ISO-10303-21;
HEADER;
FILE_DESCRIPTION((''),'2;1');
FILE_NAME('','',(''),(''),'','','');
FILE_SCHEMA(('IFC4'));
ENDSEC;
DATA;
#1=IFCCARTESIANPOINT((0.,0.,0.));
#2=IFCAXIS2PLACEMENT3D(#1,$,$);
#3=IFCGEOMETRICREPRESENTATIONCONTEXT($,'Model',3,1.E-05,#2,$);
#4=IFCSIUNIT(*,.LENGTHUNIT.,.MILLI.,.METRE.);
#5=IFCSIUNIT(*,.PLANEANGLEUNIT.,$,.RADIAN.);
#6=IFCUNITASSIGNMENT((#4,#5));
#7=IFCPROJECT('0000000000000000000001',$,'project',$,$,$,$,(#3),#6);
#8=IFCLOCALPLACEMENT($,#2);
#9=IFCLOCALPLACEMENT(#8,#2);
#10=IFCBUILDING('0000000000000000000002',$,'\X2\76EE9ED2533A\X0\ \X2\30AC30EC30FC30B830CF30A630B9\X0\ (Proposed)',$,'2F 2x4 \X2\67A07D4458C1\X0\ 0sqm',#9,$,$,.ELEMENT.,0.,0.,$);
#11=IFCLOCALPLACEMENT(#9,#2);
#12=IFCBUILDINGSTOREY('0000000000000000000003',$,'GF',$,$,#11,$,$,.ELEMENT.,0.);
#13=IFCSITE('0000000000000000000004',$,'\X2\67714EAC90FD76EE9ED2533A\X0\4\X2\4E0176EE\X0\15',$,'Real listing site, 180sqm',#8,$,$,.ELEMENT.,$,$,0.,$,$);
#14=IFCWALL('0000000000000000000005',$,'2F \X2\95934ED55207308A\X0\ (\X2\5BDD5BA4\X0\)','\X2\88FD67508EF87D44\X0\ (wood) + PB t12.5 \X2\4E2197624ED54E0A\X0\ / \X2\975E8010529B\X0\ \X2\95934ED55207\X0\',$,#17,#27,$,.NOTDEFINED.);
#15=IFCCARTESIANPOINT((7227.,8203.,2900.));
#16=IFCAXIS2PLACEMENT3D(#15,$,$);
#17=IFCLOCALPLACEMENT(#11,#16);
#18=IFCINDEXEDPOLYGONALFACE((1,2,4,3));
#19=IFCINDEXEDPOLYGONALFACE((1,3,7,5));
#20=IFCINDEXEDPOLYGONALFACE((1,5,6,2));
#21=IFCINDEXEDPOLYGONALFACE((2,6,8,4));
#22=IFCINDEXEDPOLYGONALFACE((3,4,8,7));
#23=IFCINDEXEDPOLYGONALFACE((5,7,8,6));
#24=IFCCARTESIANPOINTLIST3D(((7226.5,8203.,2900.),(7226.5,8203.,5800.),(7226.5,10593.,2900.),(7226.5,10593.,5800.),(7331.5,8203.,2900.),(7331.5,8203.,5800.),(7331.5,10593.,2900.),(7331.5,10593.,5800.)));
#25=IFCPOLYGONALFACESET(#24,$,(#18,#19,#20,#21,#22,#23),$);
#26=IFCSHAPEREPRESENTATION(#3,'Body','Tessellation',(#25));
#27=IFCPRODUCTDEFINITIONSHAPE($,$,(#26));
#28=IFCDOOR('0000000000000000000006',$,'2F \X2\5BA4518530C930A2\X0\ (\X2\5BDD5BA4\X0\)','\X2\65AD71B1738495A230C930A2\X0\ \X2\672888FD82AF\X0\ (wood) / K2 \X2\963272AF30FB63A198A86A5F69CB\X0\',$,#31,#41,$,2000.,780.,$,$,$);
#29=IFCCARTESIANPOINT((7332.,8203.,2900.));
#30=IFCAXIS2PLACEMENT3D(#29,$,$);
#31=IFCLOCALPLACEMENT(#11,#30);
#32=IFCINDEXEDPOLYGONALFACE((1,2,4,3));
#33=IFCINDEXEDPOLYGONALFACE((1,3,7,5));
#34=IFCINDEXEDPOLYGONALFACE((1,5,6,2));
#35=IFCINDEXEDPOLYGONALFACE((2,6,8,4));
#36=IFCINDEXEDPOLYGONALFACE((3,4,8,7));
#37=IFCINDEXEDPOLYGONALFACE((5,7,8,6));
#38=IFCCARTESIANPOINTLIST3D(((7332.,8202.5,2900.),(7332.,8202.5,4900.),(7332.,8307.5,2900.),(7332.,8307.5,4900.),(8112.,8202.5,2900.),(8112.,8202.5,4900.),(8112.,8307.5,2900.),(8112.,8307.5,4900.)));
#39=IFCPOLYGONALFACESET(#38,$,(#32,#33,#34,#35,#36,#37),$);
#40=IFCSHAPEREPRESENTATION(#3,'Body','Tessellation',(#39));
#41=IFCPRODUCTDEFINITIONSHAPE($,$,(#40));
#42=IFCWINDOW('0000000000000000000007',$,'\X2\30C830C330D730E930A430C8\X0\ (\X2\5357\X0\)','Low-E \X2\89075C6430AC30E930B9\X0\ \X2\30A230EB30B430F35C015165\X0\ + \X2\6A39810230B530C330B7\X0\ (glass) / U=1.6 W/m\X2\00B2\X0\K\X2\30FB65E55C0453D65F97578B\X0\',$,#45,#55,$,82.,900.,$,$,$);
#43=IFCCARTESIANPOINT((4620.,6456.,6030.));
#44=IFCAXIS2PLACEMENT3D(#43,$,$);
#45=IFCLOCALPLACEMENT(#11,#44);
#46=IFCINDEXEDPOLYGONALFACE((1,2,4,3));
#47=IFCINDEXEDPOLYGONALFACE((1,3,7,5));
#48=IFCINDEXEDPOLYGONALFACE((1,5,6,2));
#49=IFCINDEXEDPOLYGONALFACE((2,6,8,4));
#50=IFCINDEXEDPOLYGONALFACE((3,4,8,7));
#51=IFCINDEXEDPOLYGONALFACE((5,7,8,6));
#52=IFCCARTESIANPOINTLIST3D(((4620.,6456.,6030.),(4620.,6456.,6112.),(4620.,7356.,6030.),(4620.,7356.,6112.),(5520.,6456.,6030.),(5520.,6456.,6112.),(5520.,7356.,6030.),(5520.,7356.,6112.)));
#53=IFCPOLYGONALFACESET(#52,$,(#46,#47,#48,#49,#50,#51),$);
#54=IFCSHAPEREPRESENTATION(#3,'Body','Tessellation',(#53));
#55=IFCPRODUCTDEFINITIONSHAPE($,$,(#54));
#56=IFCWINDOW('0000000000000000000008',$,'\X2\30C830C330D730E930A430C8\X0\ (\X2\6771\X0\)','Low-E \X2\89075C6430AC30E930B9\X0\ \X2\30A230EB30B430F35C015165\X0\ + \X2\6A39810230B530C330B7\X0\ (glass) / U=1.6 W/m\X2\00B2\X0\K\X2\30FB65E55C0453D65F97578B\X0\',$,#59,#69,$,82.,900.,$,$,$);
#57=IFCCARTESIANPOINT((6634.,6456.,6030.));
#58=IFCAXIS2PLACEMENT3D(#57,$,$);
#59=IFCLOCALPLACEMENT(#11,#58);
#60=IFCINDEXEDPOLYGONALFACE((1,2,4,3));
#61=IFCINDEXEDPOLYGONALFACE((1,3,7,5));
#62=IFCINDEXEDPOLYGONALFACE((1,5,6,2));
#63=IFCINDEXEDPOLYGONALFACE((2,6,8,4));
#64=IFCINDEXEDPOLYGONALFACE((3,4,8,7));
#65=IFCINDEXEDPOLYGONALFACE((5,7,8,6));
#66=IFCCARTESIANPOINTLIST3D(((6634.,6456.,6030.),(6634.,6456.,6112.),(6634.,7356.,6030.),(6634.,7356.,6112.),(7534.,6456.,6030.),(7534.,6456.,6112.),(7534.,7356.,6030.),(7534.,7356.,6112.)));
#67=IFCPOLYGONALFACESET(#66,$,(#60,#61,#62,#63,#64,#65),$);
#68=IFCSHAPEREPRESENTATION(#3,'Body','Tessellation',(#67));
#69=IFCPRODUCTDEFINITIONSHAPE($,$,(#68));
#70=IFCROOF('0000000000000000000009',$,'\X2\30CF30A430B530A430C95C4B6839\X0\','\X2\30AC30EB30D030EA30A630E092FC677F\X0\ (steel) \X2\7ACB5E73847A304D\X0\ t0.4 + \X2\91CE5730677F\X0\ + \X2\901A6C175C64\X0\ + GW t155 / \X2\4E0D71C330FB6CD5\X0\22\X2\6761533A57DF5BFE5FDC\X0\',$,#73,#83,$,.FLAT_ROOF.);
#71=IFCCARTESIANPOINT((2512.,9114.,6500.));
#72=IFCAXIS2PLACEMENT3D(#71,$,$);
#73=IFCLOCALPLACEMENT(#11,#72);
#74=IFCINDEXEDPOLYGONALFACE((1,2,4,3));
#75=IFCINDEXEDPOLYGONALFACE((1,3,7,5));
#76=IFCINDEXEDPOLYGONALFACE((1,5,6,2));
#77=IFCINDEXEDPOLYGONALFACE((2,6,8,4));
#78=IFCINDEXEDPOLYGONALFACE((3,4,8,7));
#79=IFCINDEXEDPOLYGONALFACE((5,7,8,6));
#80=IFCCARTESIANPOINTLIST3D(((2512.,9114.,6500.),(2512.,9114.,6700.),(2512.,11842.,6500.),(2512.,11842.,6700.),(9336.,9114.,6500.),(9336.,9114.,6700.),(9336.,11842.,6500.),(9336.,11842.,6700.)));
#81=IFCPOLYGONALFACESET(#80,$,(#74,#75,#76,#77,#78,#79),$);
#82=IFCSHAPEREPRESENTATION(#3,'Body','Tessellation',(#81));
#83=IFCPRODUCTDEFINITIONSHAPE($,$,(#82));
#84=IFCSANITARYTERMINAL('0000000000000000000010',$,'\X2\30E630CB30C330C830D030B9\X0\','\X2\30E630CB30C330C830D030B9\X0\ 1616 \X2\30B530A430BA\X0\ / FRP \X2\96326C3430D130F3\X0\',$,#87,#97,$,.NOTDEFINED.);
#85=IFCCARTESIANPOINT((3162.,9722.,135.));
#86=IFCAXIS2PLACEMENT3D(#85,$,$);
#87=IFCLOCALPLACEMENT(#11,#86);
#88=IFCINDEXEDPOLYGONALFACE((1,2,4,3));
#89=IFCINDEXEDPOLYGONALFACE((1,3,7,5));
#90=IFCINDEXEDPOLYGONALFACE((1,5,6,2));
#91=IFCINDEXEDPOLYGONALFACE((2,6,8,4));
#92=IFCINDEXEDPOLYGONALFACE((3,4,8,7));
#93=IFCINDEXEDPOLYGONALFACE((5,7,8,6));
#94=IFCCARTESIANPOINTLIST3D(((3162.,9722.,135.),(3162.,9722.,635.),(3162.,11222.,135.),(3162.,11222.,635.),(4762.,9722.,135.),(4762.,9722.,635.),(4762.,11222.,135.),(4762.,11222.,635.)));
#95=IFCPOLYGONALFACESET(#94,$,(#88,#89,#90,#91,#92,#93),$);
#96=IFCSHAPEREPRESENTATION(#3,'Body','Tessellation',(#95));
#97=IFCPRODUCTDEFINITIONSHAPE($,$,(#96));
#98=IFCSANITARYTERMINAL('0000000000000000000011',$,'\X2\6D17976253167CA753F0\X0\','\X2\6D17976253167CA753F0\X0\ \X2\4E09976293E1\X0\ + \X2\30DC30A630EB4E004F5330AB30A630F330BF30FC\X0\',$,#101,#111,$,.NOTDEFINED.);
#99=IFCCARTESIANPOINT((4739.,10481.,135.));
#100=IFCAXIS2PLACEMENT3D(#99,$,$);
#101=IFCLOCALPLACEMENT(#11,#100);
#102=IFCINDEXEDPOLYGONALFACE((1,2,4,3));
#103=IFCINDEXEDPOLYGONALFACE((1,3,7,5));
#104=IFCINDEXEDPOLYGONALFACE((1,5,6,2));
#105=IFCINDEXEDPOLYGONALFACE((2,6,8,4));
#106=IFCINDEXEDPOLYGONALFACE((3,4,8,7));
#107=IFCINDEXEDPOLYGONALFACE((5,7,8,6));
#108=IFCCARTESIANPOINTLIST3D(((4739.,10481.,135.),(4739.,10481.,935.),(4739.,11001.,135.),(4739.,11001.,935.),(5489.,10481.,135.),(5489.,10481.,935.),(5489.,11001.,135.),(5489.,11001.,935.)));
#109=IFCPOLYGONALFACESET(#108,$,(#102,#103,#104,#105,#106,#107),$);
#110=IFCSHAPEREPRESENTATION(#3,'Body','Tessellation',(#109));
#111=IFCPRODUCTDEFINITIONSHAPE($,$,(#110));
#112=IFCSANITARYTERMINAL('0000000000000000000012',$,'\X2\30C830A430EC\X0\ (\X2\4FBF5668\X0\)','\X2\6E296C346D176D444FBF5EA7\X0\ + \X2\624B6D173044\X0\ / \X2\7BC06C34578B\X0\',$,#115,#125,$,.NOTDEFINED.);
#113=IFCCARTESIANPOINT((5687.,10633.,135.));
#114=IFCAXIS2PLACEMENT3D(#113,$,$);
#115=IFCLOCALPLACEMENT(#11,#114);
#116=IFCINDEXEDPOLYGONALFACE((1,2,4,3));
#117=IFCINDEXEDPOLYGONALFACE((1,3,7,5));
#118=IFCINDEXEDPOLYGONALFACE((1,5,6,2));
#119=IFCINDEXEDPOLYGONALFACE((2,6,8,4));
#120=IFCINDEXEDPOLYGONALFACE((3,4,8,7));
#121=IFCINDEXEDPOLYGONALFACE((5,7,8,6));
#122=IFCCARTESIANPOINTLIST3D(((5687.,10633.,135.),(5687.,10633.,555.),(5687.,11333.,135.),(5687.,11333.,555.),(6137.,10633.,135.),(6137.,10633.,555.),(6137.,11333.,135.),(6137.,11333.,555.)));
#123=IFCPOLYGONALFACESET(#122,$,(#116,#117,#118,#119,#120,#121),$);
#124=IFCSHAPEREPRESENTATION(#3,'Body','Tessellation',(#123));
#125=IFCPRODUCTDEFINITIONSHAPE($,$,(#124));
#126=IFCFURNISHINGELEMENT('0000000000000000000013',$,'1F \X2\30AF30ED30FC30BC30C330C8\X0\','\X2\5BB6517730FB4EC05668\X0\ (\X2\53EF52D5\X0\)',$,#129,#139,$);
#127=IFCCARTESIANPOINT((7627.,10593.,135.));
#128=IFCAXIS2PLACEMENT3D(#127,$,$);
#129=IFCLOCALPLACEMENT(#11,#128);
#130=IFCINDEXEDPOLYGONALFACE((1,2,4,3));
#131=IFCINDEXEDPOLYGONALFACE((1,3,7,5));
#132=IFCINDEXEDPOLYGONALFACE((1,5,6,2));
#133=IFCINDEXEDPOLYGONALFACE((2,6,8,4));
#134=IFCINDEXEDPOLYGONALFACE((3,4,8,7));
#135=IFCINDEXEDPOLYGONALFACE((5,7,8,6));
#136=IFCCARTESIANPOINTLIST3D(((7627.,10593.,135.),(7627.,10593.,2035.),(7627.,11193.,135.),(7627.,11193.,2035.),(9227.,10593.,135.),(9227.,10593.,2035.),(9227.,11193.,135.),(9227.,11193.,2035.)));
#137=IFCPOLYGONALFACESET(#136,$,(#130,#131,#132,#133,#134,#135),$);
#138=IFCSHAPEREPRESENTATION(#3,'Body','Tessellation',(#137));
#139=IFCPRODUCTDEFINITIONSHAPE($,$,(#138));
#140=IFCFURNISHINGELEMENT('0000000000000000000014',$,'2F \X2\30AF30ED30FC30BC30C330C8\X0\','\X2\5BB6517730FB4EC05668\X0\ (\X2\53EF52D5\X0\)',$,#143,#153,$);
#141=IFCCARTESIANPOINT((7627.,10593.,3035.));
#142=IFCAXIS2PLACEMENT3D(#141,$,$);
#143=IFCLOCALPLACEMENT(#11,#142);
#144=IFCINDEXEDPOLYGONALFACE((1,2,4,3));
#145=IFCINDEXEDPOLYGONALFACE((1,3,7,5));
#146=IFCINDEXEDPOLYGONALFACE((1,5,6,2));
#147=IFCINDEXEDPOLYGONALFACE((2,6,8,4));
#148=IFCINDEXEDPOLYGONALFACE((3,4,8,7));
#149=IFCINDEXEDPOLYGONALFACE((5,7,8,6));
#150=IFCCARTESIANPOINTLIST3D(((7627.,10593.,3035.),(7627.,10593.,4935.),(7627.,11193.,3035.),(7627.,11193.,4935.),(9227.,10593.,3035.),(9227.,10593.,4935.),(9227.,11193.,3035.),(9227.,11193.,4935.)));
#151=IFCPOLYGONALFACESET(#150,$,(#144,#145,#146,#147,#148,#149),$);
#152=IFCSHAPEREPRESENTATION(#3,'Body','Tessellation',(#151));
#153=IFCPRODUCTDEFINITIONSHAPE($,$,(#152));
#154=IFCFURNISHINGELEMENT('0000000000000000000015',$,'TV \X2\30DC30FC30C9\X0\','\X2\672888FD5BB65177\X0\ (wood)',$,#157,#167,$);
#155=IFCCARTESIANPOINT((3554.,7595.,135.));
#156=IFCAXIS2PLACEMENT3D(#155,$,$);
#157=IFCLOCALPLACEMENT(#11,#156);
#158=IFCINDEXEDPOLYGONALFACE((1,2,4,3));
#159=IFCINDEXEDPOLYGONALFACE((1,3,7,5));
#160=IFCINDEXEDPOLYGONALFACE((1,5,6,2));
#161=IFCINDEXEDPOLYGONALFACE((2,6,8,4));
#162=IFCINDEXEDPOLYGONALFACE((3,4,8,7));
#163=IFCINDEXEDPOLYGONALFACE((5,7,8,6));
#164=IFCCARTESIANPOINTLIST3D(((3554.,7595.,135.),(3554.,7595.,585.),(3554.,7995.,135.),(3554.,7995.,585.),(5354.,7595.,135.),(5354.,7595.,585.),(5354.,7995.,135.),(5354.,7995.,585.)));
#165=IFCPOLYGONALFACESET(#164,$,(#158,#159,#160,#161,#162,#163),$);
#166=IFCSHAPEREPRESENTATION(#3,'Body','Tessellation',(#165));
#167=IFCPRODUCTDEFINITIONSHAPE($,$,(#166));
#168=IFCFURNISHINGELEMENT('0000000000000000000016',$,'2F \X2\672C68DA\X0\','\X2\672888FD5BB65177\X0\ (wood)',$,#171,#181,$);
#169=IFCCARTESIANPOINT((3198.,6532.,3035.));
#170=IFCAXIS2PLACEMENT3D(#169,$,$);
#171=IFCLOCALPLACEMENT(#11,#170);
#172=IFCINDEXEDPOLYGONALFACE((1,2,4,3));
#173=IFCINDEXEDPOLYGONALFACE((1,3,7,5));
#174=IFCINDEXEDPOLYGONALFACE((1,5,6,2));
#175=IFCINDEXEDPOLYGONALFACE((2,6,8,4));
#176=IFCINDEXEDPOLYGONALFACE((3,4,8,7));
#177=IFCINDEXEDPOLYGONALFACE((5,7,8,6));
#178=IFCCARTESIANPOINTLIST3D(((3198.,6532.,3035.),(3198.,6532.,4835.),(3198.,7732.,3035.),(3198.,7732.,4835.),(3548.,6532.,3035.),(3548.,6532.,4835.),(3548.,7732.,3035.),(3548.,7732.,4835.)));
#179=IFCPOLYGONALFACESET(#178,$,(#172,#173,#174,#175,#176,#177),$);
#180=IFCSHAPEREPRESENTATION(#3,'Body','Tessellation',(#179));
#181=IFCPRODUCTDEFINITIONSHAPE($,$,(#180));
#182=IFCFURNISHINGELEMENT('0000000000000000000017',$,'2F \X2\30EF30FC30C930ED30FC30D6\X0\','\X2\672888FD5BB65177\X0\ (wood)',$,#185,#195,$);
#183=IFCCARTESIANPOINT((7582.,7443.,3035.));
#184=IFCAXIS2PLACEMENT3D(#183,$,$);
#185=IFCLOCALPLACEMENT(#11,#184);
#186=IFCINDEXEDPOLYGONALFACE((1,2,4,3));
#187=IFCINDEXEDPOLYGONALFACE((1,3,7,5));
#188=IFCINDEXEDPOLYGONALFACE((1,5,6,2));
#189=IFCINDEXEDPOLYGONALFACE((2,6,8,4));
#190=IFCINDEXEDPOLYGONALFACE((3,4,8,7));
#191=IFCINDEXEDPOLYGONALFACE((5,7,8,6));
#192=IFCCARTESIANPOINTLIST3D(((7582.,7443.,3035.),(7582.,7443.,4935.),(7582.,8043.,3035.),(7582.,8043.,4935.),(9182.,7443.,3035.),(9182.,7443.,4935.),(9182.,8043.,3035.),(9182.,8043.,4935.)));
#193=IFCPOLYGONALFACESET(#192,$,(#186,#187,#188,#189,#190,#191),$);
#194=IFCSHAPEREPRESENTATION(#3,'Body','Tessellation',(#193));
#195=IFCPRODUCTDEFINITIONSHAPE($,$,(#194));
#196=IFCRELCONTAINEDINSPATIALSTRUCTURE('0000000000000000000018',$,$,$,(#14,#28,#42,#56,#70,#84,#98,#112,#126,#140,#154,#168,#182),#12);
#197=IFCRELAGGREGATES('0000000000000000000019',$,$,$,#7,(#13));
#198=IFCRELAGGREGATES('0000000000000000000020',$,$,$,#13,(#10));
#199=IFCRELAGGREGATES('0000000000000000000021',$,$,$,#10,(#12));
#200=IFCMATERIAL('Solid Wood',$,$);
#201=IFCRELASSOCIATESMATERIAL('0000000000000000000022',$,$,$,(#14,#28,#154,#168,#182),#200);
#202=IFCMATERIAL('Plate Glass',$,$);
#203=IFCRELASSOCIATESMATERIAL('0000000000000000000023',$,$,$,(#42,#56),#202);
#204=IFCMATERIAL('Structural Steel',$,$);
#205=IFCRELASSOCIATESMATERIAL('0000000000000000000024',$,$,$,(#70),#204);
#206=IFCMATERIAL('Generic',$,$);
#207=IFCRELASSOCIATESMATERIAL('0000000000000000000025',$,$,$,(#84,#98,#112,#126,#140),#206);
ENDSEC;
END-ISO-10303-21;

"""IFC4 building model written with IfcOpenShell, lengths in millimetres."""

from ifc_helpers import new_model, si_unit, frame, frame_2d, origin, place, context, project, spatial, rectangle, extrude, material, element, save


model = new_model("IFC4")

# Units and contexts
model_context = context("Model", 3, precision=1e-05, world=origin())
ifc_project = project(units=[si_unit("LENGTHUNIT", "METRE", prefix="MILLI"), si_unit("PLANEANGLEUNIT", "RADIAN")], contexts=[model_context])

# Site, building, storey
site_placement = place(None, origin())
site = spatial("IfcSite", under=ifc_project, at=site_placement, Name="東京都目黒区4丁目15", ObjectType="Real listing site, 180sqm", CompositionType="ELEMENT", RefElevation=0.0)
building_placement = place(site_placement, origin())
building = spatial("IfcBuilding", under=site, at=building_placement, Name="目黒区 ガレージハウス (Proposed)", ObjectType="2F 2x4 枠組壁 0sqm", CompositionType="ELEMENT", ElevationOfRefHeight=0.0, ElevationOfTerrain=0.0)
storey_placement = place(building_placement, origin())
storey = spatial("IfcBuildingStorey", under=building, at=storey_placement, Name="GF", CompositionType="ELEMENT", Elevation=0.0)

# Shared definitions
ifc_material_1 = material(Name="Solid Wood")
ifc_material_2 = material(Name="Plate Glass")

# Wall
wall_1_placement = place(storey_placement, frame((7227.0, 8203.0, 2900.0)))
element("IfcWall", 1, at=wall_1_placement, inside=storey, material=ifc_material_1, Name="2F 間仕切り (寝室)", Description="製材軸組 (wood) + PB t12.5 両面仕上 / 非耐力 間仕切", PredefinedType="NOTDEFINED", context=model_context, shape_type="SweptSolid", body=[
    extrude(rectangle(XDim=105.0, YDim=2390.0, at=frame_2d((52.0, 1195.0))), frame((7227.0, 8203.0, 2900.0)), (0.0, 0.0, 1.0), 2900.0),
])

# Door
door_1_placement = place(storey_placement, frame((7332.0, 8203.0, 2900.0)))
element("IfcDoor", 2, at=door_1_placement, inside=storey, material=ifc_material_1, Name="2F 室内ドア (寝室)", Description="断熱玄関ドア 木製芯 (wood) / K2 防犯・採風機構", OverallHeight=2000.0, OverallWidth=780.0, context=model_context, shape_type="SweptSolid", body=[
    extrude(rectangle(XDim=780.0, YDim=105.0, at=frame_2d((390.0, 52.0))), frame((7332.0, 8203.0, 2900.0)), (0.0, 0.0, 1.0), 2000.0),
])

# Windows
window_1_placement = place(storey_placement, frame((4620.0, 6456.0, 6030.0)))
element("IfcWindow", 3, at=window_1_placement, inside=storey, material=ifc_material_2, Name="トップライト (南)", Description="Low-E 複層ガラス アルゴン封入 + 樹脂サッシ (glass) / U=1.6 W/m²K・日射取得型", OverallHeight=82.0, OverallWidth=900.0, context=model_context, shape_type="SweptSolid", body=[
    extrude(rectangle(XDim=900.0, YDim=900.0, at=frame_2d((450.0, 450.0))), frame((4620.0, 6456.0, 6030.0)), (0.0, 0.0, 1.0), 82.0),
])
window_2_placement = place(storey_placement, frame((6634.0, 6456.0, 6030.0)))
element("IfcWindow", 4, at=window_2_placement, inside=storey, material=ifc_material_2, Name="トップライト (東)", Description="Low-E 複層ガラス アルゴン封入 + 樹脂サッシ (glass) / U=1.6 W/m²K・日射取得型", OverallHeight=82.0, OverallWidth=900.0, context=model_context, shape_type="SweptSolid", body=[
    extrude(rectangle(XDim=900.0, YDim=900.0, at=frame_2d((450.0, 450.0))), frame((6634.0, 6456.0, 6030.0)), (0.0, 0.0, 1.0), 82.0),
])

# Roof
ifc_material_3 = material(Name="Structural Steel")
roof_placement = place(storey_placement, frame((2512.0, 9114.0, 6500.0)))
element("IfcRoof", 5, at=roof_placement, inside=storey, material=ifc_material_3, Name="ハイサイド屋根", Description="ガルバリウム鋼板 (steel) 立平葺き t0.4 + 野地板 + 通気層 + GW t155 / 不燃・法22条区域対応", PredefinedType="FLAT_ROOF", context=model_context, shape_type="SweptSolid", body=[
    extrude(rectangle(XDim=6824.0, YDim=2728.0, at=frame_2d((3412.0, 1364.0))), frame((2512.0, 9114.0, 6500.0)), (0.0, 0.0, 1.0), 200.0),
])

# Sanitary terminals
ifc_material_4 = material(Name="Generic")
sanitary_terminal_1_placement = place(storey_placement, frame((3162.0, 9722.0, 135.0)))
element("IfcSanitaryTerminal", 6, at=sanitary_terminal_1_placement, inside=storey, material=ifc_material_4, Name="ユニットバス", Description="ユニットバス 1616 サイズ / FRP 防水パン", PredefinedType="NOTDEFINED", context=model_context, shape_type="SweptSolid", body=[
    extrude(rectangle(XDim=1600.0, YDim=1500.0, at=frame_2d((800.0, 750.0))), frame((3162.0, 9722.0, 135.0)), (0.0, 0.0, 1.0), 500.0),
])
sanitary_terminal_2_placement = place(storey_placement, frame((4739.0, 10481.0, 135.0)))
element("IfcSanitaryTerminal", 7, at=sanitary_terminal_2_placement, inside=storey, material=ifc_material_4, Name="洗面化粧台", Description="洗面化粧台 三面鏡 + ボウル一体カウンター", PredefinedType="NOTDEFINED", context=model_context, shape_type="SweptSolid", body=[
    extrude(rectangle(XDim=750.0, YDim=520.0, at=frame_2d((375.0, 260.0))), frame((4739.0, 10481.0, 135.0)), (0.0, 0.0, 1.0), 800.0),
])
sanitary_terminal_3_placement = place(storey_placement, frame((5687.0, 10633.0, 135.0)))
element("IfcSanitaryTerminal", 8, at=sanitary_terminal_3_placement, inside=storey, material=ifc_material_4, Name="トイレ (便器)", Description="温水洗浄便座 + 手洗い / 節水型", PredefinedType="NOTDEFINED", context=model_context, shape_type="SweptSolid", body=[
    extrude(rectangle(XDim=450.0, YDim=700.0, at=frame_2d((225.0, 350.0))), frame((5687.0, 10633.0, 135.0)), (0.0, 0.0, 1.0), 420.0),
])

# Furnishing elements
furnishing_1_placement = place(storey_placement, frame((7627.0, 10593.0, 135.0)))
element("IfcFurnishingElement", 9, at=furnishing_1_placement, inside=storey, material=ifc_material_4, Name="1F クローゼット", Description="家具・什器 (可動)", context=model_context, shape_type="SweptSolid", body=[
    extrude(rectangle(XDim=1600.0, YDim=600.0, at=frame_2d((800.0, 300.0))), frame((7627.0, 10593.0, 135.0)), (0.0, 0.0, 1.0), 1900.0),
])
furnishing_2_placement = place(storey_placement, frame((7627.0, 10593.0, 3035.0)))
element("IfcFurnishingElement", 10, at=furnishing_2_placement, inside=storey, material=ifc_material_4, Name="2F クローゼット", Description="家具・什器 (可動)", context=model_context, shape_type="SweptSolid", body=[
    extrude(rectangle(XDim=1600.0, YDim=600.0, at=frame_2d((800.0, 300.0))), frame((7627.0, 10593.0, 3035.0)), (0.0, 0.0, 1.0), 1900.0),
])
furnishing_3_placement = place(storey_placement, frame((3554.0, 7595.0, 135.0)))
element("IfcFurnishingElement", 11, at=furnishing_3_placement, inside=storey, material=ifc_material_1, Name="TV ボード", Description="木製家具 (wood)", context=model_context, shape_type="SweptSolid", body=[
    extrude(rectangle(XDim=1800.0, YDim=400.0, at=frame_2d((900.0, 200.0))), frame((3554.0, 7595.0, 135.0)), (0.0, 0.0, 1.0), 450.0),
])
furnishing_4_placement = place(storey_placement, frame((3198.0, 6532.0, 3035.0)))
element("IfcFurnishingElement", 12, at=furnishing_4_placement, inside=storey, material=ifc_material_1, Name="2F 本棚", Description="木製家具 (wood)", context=model_context, shape_type="SweptSolid", body=[
    extrude(rectangle(XDim=350.0, YDim=1200.0, at=frame_2d((175.0, 600.0))), frame((3198.0, 6532.0, 3035.0)), (0.0, 0.0, 1.0), 1800.0),
])
furnishing_5_placement = place(storey_placement, frame((7582.0, 7443.0, 3035.0)))
element("IfcFurnishingElement", 13, at=furnishing_5_placement, inside=storey, material=ifc_material_1, Name="2F ワードローブ", Description="木製家具 (wood)", context=model_context, shape_type="SweptSolid", body=[
    extrude(rectangle(XDim=1600.0, YDim=600.0, at=frame_2d((800.0, 300.0))), frame((7582.0, 7443.0, 3035.0)), (0.0, 0.0, 1.0), 1900.0),
])

save(model, "model.ifc")
